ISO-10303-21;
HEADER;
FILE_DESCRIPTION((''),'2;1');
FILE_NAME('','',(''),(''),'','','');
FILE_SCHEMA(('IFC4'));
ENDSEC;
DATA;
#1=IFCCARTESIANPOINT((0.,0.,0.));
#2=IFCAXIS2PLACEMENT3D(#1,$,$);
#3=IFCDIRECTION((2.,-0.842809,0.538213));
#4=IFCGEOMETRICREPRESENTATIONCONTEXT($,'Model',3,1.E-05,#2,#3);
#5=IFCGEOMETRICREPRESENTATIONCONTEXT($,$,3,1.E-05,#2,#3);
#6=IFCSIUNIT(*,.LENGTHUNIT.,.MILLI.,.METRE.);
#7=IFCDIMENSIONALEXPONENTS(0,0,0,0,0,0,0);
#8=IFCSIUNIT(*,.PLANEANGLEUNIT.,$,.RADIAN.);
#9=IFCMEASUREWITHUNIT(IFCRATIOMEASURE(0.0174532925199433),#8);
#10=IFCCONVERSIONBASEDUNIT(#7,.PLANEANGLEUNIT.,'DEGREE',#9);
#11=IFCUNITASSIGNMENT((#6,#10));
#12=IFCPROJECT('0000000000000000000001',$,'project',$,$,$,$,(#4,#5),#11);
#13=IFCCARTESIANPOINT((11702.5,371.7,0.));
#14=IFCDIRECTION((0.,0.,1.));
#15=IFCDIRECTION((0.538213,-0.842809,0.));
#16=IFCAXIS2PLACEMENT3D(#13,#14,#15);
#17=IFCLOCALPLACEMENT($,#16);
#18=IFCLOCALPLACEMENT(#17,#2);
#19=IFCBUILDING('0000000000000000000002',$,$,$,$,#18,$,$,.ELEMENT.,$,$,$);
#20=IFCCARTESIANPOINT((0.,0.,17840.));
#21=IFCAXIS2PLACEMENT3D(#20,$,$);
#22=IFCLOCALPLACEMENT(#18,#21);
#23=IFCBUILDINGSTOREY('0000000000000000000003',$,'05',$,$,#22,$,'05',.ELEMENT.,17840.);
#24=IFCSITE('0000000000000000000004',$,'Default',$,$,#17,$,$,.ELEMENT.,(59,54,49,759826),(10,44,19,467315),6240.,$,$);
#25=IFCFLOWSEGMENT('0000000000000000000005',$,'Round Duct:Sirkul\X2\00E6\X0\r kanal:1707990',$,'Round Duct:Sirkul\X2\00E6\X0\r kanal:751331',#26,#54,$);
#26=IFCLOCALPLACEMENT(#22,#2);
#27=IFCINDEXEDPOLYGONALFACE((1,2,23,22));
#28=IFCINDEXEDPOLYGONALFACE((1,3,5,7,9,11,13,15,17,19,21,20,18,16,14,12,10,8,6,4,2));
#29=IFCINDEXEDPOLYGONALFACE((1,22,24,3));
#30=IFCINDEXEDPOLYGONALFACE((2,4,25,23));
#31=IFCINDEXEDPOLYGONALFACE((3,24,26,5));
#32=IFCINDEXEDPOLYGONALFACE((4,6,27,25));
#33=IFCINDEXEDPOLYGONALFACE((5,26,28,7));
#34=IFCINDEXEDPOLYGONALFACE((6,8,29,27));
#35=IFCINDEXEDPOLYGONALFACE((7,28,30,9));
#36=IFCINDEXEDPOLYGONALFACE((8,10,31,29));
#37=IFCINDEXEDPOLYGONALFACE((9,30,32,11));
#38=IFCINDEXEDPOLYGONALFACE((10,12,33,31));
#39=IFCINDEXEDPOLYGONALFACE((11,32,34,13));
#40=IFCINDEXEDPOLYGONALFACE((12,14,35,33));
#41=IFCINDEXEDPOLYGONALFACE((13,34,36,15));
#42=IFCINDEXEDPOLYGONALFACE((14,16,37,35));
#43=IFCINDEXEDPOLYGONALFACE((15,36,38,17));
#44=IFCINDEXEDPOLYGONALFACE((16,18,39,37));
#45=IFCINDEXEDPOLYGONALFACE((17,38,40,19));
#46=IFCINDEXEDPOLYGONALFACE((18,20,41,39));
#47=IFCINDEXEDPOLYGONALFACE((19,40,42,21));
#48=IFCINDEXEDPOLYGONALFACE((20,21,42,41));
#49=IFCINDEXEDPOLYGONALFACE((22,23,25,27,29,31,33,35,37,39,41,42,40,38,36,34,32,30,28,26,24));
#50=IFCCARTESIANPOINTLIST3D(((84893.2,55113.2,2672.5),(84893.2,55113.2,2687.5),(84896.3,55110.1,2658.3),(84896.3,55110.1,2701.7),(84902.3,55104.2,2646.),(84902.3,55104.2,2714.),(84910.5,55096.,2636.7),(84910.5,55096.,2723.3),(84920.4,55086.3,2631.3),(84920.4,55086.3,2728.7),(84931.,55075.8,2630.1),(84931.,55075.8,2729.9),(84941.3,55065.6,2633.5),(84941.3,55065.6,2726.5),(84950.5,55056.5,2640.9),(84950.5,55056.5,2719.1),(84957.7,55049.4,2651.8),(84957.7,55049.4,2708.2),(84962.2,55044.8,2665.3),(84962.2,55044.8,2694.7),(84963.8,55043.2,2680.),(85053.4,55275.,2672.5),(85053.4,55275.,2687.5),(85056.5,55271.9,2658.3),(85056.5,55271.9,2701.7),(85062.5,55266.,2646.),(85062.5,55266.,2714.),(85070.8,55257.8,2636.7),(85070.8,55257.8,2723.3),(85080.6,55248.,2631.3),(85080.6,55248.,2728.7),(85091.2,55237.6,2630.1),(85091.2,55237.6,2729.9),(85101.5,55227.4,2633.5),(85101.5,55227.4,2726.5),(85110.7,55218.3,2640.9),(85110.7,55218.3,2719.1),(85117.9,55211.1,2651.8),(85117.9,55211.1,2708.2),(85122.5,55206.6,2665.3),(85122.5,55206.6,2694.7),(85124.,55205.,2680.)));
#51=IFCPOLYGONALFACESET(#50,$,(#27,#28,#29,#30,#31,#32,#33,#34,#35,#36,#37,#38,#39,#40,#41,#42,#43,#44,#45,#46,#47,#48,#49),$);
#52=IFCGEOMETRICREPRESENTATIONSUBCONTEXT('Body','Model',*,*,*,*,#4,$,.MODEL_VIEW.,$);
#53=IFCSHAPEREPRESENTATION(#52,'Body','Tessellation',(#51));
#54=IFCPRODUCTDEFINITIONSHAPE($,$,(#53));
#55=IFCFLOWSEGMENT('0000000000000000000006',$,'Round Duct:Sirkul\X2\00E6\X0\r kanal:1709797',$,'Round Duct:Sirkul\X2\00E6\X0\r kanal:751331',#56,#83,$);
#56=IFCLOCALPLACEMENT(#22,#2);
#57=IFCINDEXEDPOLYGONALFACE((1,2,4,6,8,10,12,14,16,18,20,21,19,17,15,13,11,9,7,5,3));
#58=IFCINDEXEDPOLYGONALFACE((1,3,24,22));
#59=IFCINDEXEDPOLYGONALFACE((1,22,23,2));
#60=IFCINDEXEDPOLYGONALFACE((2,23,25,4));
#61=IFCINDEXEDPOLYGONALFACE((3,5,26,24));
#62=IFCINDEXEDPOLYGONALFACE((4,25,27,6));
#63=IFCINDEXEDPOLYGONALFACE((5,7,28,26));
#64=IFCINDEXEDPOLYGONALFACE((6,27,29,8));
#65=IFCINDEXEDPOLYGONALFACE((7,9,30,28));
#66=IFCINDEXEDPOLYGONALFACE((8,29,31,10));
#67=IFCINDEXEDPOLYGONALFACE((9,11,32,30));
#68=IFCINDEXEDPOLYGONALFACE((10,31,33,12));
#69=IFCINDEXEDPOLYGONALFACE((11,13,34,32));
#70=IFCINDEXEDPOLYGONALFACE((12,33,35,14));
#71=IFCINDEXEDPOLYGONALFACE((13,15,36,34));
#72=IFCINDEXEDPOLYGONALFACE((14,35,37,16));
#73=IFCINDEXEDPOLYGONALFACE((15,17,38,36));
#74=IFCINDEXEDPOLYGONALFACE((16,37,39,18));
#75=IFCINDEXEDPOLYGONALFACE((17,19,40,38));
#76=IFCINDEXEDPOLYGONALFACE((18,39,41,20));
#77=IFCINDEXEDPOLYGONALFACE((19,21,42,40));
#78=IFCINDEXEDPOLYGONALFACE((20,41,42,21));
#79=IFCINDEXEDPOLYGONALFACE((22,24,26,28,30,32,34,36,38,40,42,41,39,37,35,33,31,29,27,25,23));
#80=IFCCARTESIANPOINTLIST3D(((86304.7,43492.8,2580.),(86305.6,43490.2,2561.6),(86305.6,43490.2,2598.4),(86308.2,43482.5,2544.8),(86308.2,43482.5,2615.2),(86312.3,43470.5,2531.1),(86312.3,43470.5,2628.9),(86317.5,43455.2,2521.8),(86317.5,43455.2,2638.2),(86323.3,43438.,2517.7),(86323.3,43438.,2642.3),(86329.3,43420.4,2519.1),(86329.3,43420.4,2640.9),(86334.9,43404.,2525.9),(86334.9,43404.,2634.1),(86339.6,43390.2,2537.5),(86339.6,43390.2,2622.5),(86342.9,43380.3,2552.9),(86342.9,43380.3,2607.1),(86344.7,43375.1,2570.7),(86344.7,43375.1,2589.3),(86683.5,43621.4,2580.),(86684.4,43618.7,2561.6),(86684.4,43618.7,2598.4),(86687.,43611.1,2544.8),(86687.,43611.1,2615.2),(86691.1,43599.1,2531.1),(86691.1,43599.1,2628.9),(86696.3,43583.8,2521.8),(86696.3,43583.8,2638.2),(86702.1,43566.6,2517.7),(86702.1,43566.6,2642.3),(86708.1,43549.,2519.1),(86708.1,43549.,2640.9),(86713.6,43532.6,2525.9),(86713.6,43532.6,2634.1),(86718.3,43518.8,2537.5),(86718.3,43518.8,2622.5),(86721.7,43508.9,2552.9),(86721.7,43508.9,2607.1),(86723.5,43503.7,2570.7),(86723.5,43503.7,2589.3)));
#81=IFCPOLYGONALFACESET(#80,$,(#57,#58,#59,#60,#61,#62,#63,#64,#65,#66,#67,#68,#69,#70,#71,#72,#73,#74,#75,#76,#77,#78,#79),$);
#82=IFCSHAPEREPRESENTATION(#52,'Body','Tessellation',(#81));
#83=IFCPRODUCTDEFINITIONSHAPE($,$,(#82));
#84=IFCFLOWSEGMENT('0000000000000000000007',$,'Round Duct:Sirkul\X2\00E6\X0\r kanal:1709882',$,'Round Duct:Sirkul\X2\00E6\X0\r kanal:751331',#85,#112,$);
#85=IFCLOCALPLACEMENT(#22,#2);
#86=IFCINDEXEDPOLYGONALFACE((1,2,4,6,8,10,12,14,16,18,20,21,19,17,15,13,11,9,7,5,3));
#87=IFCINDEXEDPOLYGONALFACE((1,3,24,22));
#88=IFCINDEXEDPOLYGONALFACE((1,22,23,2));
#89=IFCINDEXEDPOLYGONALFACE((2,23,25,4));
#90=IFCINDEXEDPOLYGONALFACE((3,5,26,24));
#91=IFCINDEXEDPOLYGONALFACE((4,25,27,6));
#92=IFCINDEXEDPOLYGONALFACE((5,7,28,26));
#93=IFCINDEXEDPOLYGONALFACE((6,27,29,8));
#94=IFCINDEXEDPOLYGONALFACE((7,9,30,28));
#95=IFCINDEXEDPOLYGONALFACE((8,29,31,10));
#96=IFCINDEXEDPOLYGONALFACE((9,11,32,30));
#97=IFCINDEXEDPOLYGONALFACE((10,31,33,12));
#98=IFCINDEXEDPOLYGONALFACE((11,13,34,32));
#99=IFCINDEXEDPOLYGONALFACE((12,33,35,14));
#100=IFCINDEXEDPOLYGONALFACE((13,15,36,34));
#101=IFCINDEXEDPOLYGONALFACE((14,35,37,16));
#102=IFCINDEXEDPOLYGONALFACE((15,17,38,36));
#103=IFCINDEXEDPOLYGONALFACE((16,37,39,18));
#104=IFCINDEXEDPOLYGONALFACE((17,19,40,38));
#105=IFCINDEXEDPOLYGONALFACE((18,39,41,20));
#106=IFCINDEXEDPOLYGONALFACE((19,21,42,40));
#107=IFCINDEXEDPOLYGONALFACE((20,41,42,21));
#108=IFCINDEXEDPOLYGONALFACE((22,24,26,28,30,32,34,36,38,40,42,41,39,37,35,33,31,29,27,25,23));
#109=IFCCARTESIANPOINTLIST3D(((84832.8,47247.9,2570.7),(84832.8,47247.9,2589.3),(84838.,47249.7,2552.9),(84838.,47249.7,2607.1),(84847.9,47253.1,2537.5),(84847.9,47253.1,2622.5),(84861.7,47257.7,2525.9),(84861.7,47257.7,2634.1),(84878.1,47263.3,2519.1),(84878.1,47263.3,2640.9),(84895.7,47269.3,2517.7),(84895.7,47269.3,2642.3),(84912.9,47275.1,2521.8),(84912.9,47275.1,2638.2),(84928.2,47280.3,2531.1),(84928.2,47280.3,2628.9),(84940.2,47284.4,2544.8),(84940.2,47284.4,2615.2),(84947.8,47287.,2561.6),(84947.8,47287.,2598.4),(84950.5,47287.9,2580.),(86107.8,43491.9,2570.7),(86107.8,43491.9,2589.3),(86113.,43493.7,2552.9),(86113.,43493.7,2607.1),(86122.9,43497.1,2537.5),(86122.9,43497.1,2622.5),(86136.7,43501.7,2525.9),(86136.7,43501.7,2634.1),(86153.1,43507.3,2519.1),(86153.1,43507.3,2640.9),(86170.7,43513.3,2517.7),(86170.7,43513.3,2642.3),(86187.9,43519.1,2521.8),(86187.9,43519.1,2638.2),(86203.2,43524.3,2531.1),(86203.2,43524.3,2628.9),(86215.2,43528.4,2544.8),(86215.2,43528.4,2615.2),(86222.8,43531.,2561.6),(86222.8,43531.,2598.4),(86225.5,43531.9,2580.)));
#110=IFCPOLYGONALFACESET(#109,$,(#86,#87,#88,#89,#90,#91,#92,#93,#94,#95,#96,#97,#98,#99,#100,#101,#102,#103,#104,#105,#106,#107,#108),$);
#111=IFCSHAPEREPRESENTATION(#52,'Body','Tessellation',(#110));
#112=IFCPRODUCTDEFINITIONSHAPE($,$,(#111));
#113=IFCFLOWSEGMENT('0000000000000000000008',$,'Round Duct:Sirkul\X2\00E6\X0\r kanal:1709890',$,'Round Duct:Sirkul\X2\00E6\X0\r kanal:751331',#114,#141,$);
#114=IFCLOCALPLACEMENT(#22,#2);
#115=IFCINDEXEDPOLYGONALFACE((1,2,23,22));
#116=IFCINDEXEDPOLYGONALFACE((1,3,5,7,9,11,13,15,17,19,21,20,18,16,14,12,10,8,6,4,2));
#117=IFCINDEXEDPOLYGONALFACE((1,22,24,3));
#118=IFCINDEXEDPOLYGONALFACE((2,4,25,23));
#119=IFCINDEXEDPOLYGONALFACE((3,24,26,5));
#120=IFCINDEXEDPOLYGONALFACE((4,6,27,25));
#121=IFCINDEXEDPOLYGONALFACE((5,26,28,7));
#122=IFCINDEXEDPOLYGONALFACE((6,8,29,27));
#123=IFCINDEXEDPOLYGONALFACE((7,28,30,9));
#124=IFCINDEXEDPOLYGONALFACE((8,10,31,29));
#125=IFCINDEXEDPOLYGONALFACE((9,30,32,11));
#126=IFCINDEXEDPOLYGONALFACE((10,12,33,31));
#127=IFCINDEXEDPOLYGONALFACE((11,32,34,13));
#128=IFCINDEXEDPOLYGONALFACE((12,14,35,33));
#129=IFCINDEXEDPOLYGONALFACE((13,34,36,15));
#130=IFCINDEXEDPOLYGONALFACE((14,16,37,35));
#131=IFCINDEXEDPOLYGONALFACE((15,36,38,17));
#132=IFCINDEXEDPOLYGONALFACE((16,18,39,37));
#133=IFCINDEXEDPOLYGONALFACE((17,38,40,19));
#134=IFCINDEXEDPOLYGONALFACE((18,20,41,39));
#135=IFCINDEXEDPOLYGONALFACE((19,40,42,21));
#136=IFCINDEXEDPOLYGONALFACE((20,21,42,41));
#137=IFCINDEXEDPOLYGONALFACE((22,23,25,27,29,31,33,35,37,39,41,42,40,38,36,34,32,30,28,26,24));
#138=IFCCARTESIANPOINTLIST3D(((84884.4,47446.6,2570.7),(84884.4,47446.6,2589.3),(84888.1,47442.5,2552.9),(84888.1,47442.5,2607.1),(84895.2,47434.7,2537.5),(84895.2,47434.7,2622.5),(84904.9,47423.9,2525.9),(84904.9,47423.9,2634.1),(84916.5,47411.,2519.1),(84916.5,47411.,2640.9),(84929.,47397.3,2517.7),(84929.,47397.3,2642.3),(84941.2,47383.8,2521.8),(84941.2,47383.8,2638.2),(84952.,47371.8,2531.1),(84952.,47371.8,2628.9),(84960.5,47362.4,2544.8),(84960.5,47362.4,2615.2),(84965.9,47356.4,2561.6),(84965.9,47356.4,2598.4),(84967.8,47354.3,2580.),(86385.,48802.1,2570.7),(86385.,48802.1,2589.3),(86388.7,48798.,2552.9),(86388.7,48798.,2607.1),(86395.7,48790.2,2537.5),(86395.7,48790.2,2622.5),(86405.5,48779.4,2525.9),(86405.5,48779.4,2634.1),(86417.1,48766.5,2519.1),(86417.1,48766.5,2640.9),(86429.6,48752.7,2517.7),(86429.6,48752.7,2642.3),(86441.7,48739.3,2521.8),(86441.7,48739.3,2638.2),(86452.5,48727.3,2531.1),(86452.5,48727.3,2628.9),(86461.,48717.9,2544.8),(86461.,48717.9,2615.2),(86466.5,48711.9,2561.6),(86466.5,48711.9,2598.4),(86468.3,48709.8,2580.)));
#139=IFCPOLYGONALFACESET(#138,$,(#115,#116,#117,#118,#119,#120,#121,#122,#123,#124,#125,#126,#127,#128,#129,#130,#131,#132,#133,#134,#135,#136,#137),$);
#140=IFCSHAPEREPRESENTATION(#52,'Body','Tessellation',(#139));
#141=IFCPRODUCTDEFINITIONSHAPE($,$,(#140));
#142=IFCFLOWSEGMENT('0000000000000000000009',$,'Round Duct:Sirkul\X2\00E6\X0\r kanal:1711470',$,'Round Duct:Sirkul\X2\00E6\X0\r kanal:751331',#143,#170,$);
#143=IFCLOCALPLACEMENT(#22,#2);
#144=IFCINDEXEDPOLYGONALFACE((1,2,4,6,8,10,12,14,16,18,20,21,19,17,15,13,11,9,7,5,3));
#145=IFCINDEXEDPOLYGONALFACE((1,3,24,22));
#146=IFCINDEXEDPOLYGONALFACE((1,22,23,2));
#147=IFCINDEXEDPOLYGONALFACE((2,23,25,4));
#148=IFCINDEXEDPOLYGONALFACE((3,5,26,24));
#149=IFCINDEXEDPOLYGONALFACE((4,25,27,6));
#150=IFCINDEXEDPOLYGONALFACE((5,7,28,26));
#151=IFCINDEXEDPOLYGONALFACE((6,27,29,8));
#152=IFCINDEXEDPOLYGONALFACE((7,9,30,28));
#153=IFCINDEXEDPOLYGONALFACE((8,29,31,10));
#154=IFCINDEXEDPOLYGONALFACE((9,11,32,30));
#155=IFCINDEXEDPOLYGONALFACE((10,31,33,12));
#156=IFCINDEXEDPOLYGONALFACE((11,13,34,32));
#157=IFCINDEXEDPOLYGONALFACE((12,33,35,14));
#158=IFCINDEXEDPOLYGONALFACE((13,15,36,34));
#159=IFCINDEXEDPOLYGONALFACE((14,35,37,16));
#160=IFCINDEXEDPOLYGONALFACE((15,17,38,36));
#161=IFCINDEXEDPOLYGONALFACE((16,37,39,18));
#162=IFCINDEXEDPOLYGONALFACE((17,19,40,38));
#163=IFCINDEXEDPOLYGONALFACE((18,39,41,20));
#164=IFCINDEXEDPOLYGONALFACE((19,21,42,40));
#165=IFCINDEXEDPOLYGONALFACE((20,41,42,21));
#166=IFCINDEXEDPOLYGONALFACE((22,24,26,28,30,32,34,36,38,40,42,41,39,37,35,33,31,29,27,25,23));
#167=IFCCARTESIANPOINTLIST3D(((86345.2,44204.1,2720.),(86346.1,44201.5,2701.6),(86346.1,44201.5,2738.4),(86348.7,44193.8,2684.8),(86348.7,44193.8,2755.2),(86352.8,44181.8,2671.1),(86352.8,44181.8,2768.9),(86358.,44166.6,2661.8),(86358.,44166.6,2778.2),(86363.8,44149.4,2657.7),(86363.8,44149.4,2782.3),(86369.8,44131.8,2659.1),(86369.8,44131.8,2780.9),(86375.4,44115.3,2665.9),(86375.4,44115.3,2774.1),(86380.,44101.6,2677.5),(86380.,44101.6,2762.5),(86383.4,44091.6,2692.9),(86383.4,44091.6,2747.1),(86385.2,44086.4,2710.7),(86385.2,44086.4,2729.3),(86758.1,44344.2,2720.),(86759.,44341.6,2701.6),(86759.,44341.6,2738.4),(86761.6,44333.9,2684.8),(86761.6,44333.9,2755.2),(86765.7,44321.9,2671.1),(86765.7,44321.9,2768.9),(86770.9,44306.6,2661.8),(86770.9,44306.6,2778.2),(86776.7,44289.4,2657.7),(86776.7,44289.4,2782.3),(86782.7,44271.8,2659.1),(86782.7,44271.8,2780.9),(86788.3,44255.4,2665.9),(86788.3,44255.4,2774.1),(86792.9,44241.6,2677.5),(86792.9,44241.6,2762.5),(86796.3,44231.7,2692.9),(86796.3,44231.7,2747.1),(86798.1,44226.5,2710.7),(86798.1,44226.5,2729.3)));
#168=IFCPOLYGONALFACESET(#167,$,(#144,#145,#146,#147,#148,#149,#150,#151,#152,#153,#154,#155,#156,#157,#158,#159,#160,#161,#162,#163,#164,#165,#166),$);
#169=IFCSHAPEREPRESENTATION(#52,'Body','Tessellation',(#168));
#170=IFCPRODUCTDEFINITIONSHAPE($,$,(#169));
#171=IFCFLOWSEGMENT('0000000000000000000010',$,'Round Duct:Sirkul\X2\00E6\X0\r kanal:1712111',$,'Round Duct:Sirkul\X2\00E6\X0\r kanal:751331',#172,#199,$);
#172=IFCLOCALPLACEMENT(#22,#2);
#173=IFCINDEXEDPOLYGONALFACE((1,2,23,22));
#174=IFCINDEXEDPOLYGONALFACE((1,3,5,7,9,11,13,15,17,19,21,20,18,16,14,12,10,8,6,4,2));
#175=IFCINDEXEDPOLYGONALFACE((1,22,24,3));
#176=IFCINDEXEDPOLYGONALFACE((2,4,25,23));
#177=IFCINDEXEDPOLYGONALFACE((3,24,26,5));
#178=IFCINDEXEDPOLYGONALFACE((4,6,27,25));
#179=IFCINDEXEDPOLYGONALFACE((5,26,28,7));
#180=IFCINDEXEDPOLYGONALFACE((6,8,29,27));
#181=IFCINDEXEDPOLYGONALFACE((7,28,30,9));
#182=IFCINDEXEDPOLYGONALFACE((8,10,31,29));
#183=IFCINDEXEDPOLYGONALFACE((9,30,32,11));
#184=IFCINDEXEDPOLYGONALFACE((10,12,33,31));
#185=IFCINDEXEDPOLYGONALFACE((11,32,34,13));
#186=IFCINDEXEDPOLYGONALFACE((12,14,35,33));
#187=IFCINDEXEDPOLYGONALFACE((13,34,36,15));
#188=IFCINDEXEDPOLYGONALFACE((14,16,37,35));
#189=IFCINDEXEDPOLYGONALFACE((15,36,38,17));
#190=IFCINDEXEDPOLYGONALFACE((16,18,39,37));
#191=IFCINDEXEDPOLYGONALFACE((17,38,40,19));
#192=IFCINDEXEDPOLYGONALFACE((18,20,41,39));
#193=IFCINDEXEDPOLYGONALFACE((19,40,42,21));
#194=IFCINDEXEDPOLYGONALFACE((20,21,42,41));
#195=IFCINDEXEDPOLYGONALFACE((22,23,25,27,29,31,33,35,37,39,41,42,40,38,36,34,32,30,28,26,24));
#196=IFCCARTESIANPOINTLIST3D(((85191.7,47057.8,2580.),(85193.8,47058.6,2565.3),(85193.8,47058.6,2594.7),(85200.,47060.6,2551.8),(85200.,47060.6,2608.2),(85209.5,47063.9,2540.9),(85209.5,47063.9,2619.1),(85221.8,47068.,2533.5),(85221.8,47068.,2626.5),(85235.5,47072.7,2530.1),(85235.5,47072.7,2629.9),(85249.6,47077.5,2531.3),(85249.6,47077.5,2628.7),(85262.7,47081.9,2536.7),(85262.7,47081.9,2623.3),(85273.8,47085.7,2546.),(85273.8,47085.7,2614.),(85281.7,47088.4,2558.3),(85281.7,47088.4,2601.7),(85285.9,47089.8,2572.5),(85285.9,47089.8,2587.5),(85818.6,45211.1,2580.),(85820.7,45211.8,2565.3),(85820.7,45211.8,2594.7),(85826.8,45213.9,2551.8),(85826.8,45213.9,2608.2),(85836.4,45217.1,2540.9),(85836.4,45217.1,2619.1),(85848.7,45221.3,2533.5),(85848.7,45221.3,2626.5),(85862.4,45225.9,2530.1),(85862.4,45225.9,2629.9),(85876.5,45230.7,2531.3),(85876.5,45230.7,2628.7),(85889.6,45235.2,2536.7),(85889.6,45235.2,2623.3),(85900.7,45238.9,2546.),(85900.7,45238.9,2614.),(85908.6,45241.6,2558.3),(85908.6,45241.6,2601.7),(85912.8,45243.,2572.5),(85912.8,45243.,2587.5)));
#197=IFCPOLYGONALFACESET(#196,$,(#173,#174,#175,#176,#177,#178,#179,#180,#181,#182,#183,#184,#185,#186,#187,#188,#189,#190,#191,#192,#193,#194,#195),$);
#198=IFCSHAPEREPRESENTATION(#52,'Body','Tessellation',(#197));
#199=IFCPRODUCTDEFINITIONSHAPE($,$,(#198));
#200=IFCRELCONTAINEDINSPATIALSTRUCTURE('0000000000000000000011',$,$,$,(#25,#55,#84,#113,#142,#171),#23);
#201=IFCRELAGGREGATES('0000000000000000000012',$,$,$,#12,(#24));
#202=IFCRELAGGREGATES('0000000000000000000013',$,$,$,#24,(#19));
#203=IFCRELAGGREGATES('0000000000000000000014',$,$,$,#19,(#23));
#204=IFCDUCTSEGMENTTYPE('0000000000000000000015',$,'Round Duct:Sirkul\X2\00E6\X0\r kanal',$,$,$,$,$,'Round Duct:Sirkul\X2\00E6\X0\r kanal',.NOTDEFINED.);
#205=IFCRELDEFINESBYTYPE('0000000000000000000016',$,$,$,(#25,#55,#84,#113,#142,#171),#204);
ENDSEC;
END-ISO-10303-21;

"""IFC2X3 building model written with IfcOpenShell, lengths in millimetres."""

from ifc_helpers import new_model, entity, si_unit, converted_unit, direction, frame, origin, origin_2d_with_axis, place, context, subcontext, project, spatial, circle, extrude, type_object, element, save


model = new_model("IFC2X3")

# Units and contexts
model_context = context("Model", 3, precision=1e-05, world=origin(), true_north=direction((2.0, -0.842809, 0.538213)))
context_of_model = context(None, 3, precision=1e-05, world=origin(), true_north=direction((2.0, -0.842809, 0.538213)))
body_context = subcontext(model_context, "Body", "Model", "MODEL_VIEW")
ifc_project = project(units=[si_unit("LENGTHUNIT", "METRE", prefix="MILLI"), converted_unit("PLANEANGLEUNIT", "DEGREE", entity("IfcRatioMeasure", 0.0174532925199433), si_unit("PLANEANGLEUNIT", "RADIAN"), dimensions=[0, 0, 0, 0, 0, 0, 0])], contexts=[model_context, context_of_model])

# Site, building, storey
site_placement = place(None, frame((11702.5, 371.7, 0.0), z_axis=(0.0, 0.0, 1.0), x_axis=(0.538213, -0.842809, 0.0)))
site = spatial("IfcSite", under=ifc_project, at=site_placement, Name="Default", CompositionType="ELEMENT", RefLatitude=(59, 54, 49, 759826), RefLongitude=(10, 44, 19, 467315), RefElevation=6240.0)
building_placement = place(site_placement, origin())
building = spatial("IfcBuilding", under=site, at=building_placement, CompositionType="ELEMENT")
storey_placement = place(building_placement, frame((0.0, 0.0, 17840.0)))
storey = spatial("IfcBuildingStorey", under=building, at=storey_placement, Name="05", LongName="05", CompositionType="ELEMENT", Elevation=17840.0)

# Flow segments
duct_segment_type = type_object("IfcDuctSegmentType", Name="Round Duct:Sirkulær kanal", ElementType="Round Duct:Sirkulær kanal", PredefinedType="NOTDEFINED")
flow_segment_1_placement = place(storey_placement, origin())
element("IfcFlowSegment", 1, at=flow_segment_1_placement, inside=storey, type_object=duct_segment_type, Name="Round Duct:Sirkulær kanal:1707990", ObjectType="Round Duct:Sirkulær kanal:751331", context=body_context, shape_type="SweptSolid", body=[
    extrude(circle(Radius=50.0, at=origin_2d_with_axis()), frame((84928.3, 55078.4, 2680.0), z_axis=(0.703669, 0.710528, 0.0), x_axis=(0.710528, -0.703669, 0.0)), (0.0, 0.0, 1.0), 227.7),
])
flow_segment_2_placement = place(storey_placement, origin())
element("IfcFlowSegment", 2, at=flow_segment_2_placement, inside=storey, type_object=duct_segment_type, Name="Round Duct:Sirkulær kanal:1709797", ObjectType="Round Duct:Sirkulær kanal:751331", context=body_context, shape_type="SweptSolid", body=[
    extrude(circle(Radius=62.5, at=origin_2d_with_axis()), frame((86324.8, 43433.6, 2580.0), z_axis=(0.94693, 0.321439, 0.0), x_axis=(-0.321439, 0.94693, 0.0)), (0.0, 0.0, 1.0), 400.0),
])
flow_segment_3_placement = place(storey_placement, origin())
element("IfcFlowSegment", 3, at=flow_segment_3_placement, inside=storey, type_object=duct_segment_type, Name="Round Duct:Sirkulær kanal:1709882", ObjectType="Round Duct:Sirkulær kanal:751331", context=body_context, shape_type="SweptSolid", body=[
    extrude(circle(Radius=62.5, at=origin_2d_with_axis()), frame((86166.3, 43511.8, 2580.0), z_axis=(-0.321439, 0.94693, 0.0), x_axis=(0.94693, 0.321439, 0.0)), (0.0, 0.0, 1.0), 3966.5),
])
flow_segment_4_placement = place(storey_placement, origin())
element("IfcFlowSegment", 4, at=flow_segment_4_placement, inside=storey, type_object=duct_segment_type, Name="Round Duct:Sirkulær kanal:1709890", ObjectType="Round Duct:Sirkulær kanal:751331", context=body_context, shape_type="SweptSolid", body=[
    extrude(circle(Radius=62.5, at=origin_2d_with_axis()), frame((84925.9, 47400.7, 2580.0), z_axis=(0.742063, 0.67033, 0.0), x_axis=(0.67033, -0.742063, 0.0)), (0.0, 0.0, 1.0), 2022.1),
])
flow_segment_5_placement = place(storey_placement, origin())
element("IfcFlowSegment", 5, at=flow_segment_5_placement, inside=storey, type_object=duct_segment_type, Name="Round Duct:Sirkulær kanal:1711470", ObjectType="Round Duct:Sirkulær kanal:751331", context=body_context, shape_type="SweptSolid", body=[
    extrude(circle(Radius=62.5, at=origin_2d_with_axis()), frame((86365.3, 44144.9, 2720.0), z_axis=(0.946996, 0.321245, 0.0), x_axis=(-0.321245, 0.946996, 0.0)), (0.0, 0.0, 1.0), 436.0),
])
flow_segment_6_placement = place(storey_placement, origin())
element("IfcFlowSegment", 6, at=flow_segment_6_placement, inside=storey, type_object=duct_segment_type, Name="Round Duct:Sirkulær kanal:1712111", ObjectType="Round Duct:Sirkulær kanal:751331", context=body_context, shape_type="SweptSolid", body=[
    extrude(circle(Radius=50.0, at=origin_2d_with_axis()), frame((85239.1, 47073.9, 2580.0), z_axis=(0.321439, -0.94693, 0.0), x_axis=(-0.94693, -0.321439, 0.0)), (0.0, 0.0, 1.0), 1950.3),
])

save(model, "model.ifc")
